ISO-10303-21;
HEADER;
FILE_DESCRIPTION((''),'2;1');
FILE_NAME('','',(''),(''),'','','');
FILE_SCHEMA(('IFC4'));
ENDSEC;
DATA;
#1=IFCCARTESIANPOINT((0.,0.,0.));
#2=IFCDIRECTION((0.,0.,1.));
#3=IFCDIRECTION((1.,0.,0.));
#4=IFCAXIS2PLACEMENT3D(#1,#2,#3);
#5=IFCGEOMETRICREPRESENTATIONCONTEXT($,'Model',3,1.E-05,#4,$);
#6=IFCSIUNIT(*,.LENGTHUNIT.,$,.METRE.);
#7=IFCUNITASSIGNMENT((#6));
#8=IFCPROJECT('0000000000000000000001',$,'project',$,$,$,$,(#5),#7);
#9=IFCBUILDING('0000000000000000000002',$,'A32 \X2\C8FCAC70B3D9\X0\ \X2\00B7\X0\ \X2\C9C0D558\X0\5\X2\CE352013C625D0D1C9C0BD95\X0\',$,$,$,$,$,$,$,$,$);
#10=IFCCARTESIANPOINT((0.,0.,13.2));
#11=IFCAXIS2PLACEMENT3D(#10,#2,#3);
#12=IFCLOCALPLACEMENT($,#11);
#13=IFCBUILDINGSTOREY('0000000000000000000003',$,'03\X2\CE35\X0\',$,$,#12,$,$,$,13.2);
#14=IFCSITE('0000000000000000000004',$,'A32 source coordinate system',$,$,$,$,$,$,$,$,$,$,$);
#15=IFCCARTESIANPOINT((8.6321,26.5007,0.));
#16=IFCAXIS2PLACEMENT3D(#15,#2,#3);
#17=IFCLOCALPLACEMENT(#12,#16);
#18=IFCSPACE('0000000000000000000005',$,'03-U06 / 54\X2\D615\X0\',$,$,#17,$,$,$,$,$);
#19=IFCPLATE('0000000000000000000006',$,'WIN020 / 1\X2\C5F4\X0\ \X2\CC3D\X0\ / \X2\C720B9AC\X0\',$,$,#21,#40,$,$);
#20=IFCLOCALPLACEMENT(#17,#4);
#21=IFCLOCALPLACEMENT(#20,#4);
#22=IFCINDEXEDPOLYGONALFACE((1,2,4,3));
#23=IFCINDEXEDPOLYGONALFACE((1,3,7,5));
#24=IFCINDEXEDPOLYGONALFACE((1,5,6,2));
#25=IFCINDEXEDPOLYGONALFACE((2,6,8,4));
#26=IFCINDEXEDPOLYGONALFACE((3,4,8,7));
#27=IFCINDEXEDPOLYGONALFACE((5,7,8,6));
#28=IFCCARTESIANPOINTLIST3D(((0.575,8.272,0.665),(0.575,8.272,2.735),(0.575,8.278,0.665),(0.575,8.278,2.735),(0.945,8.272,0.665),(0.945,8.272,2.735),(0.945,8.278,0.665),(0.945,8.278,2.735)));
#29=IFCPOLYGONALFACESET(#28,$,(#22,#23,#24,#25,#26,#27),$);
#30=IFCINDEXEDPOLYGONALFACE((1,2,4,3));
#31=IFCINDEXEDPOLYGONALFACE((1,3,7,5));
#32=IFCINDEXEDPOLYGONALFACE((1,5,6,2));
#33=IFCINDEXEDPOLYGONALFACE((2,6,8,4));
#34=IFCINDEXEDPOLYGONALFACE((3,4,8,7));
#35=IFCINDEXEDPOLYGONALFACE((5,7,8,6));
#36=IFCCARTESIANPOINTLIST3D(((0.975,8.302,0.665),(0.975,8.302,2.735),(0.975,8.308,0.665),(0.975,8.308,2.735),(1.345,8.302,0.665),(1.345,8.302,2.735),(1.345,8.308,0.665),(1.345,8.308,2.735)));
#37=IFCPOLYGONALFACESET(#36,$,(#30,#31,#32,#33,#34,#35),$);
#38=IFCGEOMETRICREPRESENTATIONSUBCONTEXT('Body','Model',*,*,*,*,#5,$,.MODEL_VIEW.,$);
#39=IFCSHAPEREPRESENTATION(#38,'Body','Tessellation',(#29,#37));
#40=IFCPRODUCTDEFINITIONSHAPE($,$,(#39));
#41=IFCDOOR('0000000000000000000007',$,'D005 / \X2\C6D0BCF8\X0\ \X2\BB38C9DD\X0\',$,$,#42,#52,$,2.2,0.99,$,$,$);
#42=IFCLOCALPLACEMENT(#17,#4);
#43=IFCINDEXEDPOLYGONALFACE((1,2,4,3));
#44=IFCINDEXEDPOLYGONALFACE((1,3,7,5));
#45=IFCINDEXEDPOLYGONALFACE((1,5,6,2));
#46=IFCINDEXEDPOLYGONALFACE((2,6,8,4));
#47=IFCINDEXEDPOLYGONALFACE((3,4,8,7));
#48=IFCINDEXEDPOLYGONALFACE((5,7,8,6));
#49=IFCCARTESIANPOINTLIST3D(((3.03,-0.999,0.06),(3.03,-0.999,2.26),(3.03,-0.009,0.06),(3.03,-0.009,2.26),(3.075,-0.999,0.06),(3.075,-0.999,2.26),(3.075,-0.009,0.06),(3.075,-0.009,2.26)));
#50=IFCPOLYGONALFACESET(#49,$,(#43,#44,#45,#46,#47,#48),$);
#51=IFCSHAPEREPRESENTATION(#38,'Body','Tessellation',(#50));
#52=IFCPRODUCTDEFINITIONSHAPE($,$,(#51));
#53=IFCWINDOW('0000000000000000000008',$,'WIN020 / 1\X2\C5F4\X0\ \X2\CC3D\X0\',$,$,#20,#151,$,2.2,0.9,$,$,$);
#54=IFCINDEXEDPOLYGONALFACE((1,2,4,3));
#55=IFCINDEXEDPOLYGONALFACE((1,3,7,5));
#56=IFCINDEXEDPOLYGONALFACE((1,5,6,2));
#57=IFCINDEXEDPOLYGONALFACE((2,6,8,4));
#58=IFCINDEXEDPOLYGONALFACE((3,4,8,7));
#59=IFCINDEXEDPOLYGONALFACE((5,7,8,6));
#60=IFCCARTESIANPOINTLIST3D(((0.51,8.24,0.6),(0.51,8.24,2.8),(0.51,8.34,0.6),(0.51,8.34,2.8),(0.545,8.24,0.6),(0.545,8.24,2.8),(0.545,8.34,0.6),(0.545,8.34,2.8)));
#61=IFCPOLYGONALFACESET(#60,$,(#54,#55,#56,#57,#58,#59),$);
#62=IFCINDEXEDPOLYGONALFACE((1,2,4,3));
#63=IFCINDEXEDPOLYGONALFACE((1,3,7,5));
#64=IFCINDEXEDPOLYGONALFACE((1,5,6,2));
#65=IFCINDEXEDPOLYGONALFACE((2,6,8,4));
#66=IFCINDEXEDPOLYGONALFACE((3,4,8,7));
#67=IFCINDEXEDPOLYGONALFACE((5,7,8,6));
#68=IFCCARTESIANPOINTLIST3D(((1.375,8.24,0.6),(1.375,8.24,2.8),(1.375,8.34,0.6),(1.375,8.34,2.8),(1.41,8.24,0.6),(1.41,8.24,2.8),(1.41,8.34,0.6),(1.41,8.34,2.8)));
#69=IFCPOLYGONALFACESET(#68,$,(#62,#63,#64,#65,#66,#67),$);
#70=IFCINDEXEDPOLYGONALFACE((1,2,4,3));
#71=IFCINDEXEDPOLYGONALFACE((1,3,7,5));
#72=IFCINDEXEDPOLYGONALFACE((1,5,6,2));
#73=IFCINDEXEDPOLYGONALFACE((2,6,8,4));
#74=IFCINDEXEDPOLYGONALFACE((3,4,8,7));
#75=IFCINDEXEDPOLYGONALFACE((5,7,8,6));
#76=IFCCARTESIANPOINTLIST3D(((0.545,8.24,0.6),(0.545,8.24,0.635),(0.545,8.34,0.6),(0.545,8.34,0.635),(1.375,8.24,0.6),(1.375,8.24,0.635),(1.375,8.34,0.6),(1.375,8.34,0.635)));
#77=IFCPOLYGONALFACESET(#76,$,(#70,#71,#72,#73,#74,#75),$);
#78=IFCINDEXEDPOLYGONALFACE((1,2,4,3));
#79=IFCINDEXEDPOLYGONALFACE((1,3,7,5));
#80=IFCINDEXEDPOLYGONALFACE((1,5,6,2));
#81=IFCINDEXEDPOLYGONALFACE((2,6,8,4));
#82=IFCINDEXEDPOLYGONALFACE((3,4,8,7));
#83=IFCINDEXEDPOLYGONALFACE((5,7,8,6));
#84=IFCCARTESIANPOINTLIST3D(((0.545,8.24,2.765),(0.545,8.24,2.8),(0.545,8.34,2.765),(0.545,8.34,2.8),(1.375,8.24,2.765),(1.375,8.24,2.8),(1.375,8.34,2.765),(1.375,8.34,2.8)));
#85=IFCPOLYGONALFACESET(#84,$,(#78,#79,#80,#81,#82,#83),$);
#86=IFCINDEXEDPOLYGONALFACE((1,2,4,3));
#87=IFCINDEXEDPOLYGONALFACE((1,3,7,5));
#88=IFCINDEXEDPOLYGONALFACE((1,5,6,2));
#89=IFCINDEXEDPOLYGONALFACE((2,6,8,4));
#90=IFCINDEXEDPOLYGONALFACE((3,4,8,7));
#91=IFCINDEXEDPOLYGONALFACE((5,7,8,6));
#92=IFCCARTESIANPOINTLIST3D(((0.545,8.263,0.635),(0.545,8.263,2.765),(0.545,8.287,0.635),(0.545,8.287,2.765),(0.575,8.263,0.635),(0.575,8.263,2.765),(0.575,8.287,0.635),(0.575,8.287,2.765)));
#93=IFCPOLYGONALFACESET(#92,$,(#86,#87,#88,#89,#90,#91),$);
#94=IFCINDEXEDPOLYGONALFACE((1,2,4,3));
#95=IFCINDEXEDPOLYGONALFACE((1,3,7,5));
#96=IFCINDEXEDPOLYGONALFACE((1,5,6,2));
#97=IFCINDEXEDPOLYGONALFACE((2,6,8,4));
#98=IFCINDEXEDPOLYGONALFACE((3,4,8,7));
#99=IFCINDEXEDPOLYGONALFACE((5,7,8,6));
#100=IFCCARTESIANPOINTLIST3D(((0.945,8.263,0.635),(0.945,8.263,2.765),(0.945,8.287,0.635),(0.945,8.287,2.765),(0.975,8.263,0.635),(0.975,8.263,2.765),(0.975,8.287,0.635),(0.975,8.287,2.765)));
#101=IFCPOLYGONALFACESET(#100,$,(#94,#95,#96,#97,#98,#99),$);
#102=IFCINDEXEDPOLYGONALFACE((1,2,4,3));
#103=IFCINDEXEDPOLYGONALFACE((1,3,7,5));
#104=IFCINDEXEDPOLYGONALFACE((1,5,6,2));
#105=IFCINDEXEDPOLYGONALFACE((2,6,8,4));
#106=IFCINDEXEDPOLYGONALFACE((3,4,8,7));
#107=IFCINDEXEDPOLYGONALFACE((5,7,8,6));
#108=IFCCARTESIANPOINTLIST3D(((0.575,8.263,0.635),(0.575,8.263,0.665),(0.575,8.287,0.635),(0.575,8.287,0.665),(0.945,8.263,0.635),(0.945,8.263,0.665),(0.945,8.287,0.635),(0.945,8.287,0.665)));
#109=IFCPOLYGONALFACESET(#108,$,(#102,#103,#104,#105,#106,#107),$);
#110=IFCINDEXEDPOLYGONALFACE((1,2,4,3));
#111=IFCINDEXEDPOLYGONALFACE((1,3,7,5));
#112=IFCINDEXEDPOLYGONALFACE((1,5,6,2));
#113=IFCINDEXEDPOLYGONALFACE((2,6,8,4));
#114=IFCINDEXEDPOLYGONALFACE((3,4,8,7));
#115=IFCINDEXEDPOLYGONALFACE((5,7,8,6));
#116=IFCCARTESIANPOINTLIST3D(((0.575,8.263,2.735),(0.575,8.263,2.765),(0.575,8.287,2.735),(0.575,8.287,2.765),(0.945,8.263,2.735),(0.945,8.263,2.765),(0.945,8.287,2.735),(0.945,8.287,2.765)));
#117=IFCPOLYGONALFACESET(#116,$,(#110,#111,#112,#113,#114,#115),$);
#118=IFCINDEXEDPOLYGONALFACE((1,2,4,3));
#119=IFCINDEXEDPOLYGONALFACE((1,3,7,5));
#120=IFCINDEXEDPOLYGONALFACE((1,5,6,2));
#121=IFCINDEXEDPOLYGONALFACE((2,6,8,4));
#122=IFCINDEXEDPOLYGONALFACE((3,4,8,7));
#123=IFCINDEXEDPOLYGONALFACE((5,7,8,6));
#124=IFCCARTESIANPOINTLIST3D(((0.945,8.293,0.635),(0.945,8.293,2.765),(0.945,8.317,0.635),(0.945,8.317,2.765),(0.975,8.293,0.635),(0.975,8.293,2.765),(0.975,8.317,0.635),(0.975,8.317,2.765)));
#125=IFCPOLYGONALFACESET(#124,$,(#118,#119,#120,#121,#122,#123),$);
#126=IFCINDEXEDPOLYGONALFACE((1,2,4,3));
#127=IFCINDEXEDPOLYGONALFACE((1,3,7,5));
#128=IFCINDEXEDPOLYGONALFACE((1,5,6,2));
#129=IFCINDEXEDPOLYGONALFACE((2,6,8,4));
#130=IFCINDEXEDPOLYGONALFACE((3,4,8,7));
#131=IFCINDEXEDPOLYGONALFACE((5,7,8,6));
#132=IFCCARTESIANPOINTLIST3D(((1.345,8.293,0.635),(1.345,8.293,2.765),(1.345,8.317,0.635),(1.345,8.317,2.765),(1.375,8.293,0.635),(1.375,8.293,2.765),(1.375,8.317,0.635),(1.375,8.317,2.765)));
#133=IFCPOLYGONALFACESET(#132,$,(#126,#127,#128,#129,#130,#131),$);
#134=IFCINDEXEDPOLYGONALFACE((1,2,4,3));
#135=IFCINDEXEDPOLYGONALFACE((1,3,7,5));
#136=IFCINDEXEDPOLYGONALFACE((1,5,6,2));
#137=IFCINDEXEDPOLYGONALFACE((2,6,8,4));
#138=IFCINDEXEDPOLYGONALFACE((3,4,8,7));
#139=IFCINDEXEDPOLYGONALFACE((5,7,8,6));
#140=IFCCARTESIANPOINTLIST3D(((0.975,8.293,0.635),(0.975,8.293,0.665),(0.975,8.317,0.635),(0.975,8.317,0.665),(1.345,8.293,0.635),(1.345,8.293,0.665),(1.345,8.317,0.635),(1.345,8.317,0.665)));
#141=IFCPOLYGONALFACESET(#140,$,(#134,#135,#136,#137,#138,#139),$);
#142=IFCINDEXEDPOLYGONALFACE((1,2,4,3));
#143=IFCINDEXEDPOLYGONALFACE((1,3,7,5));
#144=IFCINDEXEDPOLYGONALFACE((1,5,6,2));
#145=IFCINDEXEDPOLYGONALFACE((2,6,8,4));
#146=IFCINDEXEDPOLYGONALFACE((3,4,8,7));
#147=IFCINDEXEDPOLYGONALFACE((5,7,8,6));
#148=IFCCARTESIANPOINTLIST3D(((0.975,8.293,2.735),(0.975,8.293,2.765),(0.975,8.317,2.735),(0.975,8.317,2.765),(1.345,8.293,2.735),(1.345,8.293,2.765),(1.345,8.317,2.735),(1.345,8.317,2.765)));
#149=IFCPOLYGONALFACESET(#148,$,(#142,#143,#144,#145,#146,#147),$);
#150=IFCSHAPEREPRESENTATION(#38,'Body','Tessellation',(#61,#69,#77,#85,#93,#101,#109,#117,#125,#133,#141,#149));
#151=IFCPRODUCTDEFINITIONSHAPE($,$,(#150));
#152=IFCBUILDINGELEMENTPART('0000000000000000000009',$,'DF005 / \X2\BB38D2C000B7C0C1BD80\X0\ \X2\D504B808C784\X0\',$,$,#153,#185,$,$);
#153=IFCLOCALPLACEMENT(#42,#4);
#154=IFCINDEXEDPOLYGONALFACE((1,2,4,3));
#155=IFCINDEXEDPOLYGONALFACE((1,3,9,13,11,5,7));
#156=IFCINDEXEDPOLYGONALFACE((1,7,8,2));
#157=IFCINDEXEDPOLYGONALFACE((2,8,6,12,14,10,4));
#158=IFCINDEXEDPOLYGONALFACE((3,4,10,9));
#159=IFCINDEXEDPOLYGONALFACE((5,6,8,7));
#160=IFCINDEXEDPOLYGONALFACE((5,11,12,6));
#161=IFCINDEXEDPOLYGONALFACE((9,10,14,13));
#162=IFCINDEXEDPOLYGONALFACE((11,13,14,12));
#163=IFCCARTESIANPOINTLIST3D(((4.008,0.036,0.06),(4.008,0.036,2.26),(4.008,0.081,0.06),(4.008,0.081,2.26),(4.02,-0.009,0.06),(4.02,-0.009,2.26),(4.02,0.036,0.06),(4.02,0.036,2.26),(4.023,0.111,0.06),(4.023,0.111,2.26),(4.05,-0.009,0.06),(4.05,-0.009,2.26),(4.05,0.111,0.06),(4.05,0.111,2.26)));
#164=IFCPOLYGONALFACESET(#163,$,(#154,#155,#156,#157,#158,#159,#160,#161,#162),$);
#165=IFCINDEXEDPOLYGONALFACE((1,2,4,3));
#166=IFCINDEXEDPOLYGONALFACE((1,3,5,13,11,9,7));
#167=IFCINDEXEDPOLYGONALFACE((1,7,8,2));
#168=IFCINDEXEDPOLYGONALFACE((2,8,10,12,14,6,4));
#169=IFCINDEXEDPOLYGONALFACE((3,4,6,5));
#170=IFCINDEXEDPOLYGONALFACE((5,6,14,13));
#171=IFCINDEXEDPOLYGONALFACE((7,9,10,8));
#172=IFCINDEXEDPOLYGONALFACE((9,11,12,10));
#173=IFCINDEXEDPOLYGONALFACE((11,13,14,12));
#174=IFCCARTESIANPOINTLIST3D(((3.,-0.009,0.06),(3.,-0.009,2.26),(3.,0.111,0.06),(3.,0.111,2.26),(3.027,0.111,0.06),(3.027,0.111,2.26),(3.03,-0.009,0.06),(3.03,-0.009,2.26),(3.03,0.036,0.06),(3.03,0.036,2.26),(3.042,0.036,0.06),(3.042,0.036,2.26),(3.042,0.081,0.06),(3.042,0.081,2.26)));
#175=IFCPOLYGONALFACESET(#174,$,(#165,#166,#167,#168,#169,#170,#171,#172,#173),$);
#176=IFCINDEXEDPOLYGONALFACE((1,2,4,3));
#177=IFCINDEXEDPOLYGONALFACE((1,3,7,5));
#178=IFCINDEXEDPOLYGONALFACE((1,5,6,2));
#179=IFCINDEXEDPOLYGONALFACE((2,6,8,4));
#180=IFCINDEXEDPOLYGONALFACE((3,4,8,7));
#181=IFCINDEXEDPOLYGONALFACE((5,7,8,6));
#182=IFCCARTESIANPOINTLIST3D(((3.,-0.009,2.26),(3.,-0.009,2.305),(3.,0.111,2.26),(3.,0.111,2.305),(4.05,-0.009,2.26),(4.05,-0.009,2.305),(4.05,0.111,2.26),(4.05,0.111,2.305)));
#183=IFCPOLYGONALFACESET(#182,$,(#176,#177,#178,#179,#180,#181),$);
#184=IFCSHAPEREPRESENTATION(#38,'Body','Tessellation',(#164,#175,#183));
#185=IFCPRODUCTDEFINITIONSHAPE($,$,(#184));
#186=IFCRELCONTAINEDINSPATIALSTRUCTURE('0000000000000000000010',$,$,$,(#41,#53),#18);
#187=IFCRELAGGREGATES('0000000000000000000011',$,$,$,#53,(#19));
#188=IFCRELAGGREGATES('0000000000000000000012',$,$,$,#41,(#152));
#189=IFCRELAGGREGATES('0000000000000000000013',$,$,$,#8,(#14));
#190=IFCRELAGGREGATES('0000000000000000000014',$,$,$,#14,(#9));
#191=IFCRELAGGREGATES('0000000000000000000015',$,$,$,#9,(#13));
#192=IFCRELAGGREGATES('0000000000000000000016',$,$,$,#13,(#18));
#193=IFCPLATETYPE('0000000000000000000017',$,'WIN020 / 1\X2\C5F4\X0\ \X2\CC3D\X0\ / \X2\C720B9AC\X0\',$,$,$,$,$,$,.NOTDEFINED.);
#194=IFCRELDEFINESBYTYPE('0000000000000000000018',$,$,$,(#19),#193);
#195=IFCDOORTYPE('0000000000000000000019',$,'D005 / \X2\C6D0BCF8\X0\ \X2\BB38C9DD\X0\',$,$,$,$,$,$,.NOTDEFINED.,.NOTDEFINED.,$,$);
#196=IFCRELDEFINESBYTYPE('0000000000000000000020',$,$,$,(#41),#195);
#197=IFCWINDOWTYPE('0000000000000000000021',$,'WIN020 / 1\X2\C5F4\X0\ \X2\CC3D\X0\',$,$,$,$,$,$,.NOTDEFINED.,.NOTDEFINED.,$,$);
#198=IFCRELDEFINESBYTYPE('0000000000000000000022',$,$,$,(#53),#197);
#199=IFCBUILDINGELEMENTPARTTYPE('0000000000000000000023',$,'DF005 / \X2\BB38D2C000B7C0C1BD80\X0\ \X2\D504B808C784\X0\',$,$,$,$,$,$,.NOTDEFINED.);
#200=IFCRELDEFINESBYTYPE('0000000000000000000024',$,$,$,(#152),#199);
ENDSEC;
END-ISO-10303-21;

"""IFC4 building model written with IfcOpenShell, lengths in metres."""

from ifc_helpers import new_model, si_unit, frame, origin, origin_with_axes, place, context, subcontext, project, spatial, polyline, outline, extrude, source, transform, mapped, type_object, type_shapes, element, aggregate, save


model = new_model("IFC4")

# Units and contexts
model_context = context("Model", 3, precision=1e-05, world=origin_with_axes())
body_context = subcontext(model_context, "Body", "Model", "MODEL_VIEW")
ifc_project = project(units=[si_unit("LENGTHUNIT", "METRE")], contexts=[model_context])

# Plate
storey_placement = place(None, frame((0.0, 0.0, 13.2), z_axis=(0.0, 0.0, 1.0), x_axis=(1.0, 0.0, 0.0)))
space_1_placement = place(storey_placement, frame((8.6321, 26.5007, 0.0), z_axis=(0.0, 0.0, 1.0), x_axis=(1.0, 0.0, 0.0)))
plate_type_1 = type_object("IfcPlateType", Name="WIN020 / 1열 창 / 유리", PredefinedType="NOTDEFINED")
shared_shape_1 = source(origin(), body_context, "Body", "SweptSolid", [
    extrude(outline(polyline([(0.575, 8.272), (0.575, 8.278), (0.945, 8.278), (0.945, 8.272), (0.575, 8.272)])), frame((0.0, 0.0, 0.665)), (0.0, 0.0, 1.0), 2.07),
    extrude(outline(polyline([(0.975, 8.302), (0.975, 8.308), (1.345, 8.308), (1.345, 8.302), (0.975, 8.302)])), frame((0.0, 0.0, 0.665)), (0.0, 0.0, 1.0), 2.07),
])
type_shapes(plate_type_1, [shared_shape_1])
window_1_placement = place(space_1_placement, origin_with_axes())
plate_1_placement = place(window_1_placement, origin_with_axes())
plate_1 = element("IfcPlate", 1, at=plate_1_placement, type_object=plate_type_1, Name="WIN020 / 1열 창 / 유리", context=body_context, shape_type="MappedRepresentation", body=[
    mapped(shared_shape_1, transform((0.0, 0.0, 0.0), scale=1.0)),
])

# Site, building, storey, space
site = spatial("IfcSite", under=ifc_project, Name="A32 source coordinate system")
building = spatial("IfcBuilding", under=site, Name="A32 주거동 · 지하5층–옥탑지붕")
storey = spatial("IfcBuildingStorey", under=building, at=storey_placement, Name="03층", Elevation=13.2)
space_1 = spatial("IfcSpace", under=storey, at=space_1_placement, Name="03-U06 / 54형")

# Door
door_type_1 = type_object("IfcDoorType", Name="D005 / 원본 문짝", OperationType="NOTDEFINED", PredefinedType="NOTDEFINED")
shared_shape_2 = source(origin(), body_context, "Body", "SweptSolid", [
    extrude(outline(polyline([(3.075, -0.999), (3.03, -0.999), (3.03, -0.009), (3.075, -0.009), (3.075, -0.999)])), frame((0.0, 0.0, 0.06)), (0.0, 0.0, 1.0), 2.2),
])
type_shapes(door_type_1, [shared_shape_2])
door_1_placement = place(space_1_placement, origin_with_axes())
door_1 = element("IfcDoor", 2, at=door_1_placement, inside=space_1, type_object=door_type_1, Name="D005 / 원본 문짝", OverallHeight=2.2, OverallWidth=0.99, context=body_context, shape_type="MappedRepresentation", body=[
    mapped(shared_shape_2, transform((0.0, 0.0, 0.0), scale=1.0)),
])

# Window
window_type_1 = type_object("IfcWindowType", Name="WIN020 / 1열 창", PartitioningType="NOTDEFINED", PredefinedType="NOTDEFINED")
shared_shape_3 = source(origin(), body_context, "Body", "SweptSolid", [
    extrude(outline(polyline([(0.51, 8.24), (0.51, 8.34), (0.545, 8.34), (0.545, 8.24), (0.51, 8.24)])), frame((0.0, 0.0, 0.6)), (0.0, 0.0, 1.0), 2.2),
    extrude(outline(polyline([(1.375, 8.24), (1.375, 8.34), (1.41, 8.34), (1.41, 8.24), (1.375, 8.24)])), frame((0.0, 0.0, 0.6)), (0.0, 0.0, 1.0), 2.2),
    extrude(outline(polyline([(0.545, 8.24), (0.545, 8.34), (1.375, 8.34), (1.375, 8.24), (0.545, 8.24)])), frame((0.0, 0.0, 0.6)), (0.0, 0.0, 1.0), 0.035),
    extrude(outline(polyline([(0.545, 8.24), (0.545, 8.34), (1.375, 8.34), (1.375, 8.24), (0.545, 8.24)])), frame((0.0, 0.0, 2.765)), (0.0, 0.0, 1.0), 0.035),
    extrude(outline(polyline([(0.545, 8.263), (0.545, 8.287), (0.575, 8.287), (0.575, 8.263), (0.545, 8.263)])), frame((0.0, 0.0, 0.635)), (0.0, 0.0, 1.0), 2.13),
    extrude(outline(polyline([(0.945, 8.263), (0.945, 8.287), (0.975, 8.287), (0.975, 8.263), (0.945, 8.263)])), frame((0.0, 0.0, 0.635)), (0.0, 0.0, 1.0), 2.13),
    extrude(outline(polyline([(0.575, 8.263), (0.575, 8.287), (0.945, 8.287), (0.945, 8.263), (0.575, 8.263)])), frame((0.0, 0.0, 0.635)), (0.0, 0.0, 1.0), 0.03),
    extrude(outline(polyline([(0.575, 8.263), (0.575, 8.287), (0.945, 8.287), (0.945, 8.263), (0.575, 8.263)])), frame((0.0, 0.0, 2.735)), (0.0, 0.0, 1.0), 0.03),
    extrude(outline(polyline([(0.945, 8.293), (0.945, 8.317), (0.975, 8.317), (0.975, 8.293), (0.945, 8.293)])), frame((0.0, 0.0, 0.635)), (0.0, 0.0, 1.0), 2.13),
    extrude(outline(polyline([(1.345, 8.293), (1.345, 8.317), (1.375, 8.317), (1.375, 8.293), (1.345, 8.293)])), frame((0.0, 0.0, 0.635)), (0.0, 0.0, 1.0), 2.13),
    extrude(outline(polyline([(0.975, 8.293), (0.975, 8.317), (1.345, 8.317), (1.345, 8.293), (0.975, 8.293)])), frame((0.0, 0.0, 0.635)), (0.0, 0.0, 1.0), 0.03),
    extrude(outline(polyline([(0.975, 8.293), (0.975, 8.317), (1.345, 8.317), (1.345, 8.293), (0.975, 8.293)])), frame((0.0, 0.0, 2.735)), (0.0, 0.0, 1.0), 0.03),
])
type_shapes(window_type_1, [shared_shape_3])
window_1 = element("IfcWindow", 3, at=window_1_placement, inside=space_1, type_object=window_type_1, Name="WIN020 / 1열 창", OverallHeight=2.2, OverallWidth=0.9, context=body_context, shape_type="MappedRepresentation", body=[
    mapped(shared_shape_3, transform((0.0, 0.0, 0.0), scale=1.0)),
])
aggregate(window_1, [plate_1])

# Building element part
building_element_part_type_1 = type_object("IfcBuildingElementPartType", Name="DF005 / 문틀·상부 프레임", PredefinedType="NOTDEFINED")
shared_shape_4 = source(origin(), body_context, "Body", "SweptSolid", [
    extrude(outline(polyline([(4.02, -0.009), (4.02, 0.036), (4.008, 0.036), (4.008, 0.081), (4.023, 0.111), (4.05, 0.111), (4.05, -0.009), (4.02, -0.009)])), frame((0.0, 0.0, 0.06)), (0.0, 0.0, 1.0), 2.2),
    extrude(outline(polyline([(3.0, 0.111), (3.027, 0.111), (3.042, 0.081), (3.042, 0.036), (3.03, 0.036), (3.03, -0.009), (3.0, -0.009), (3.0, 0.111)])), frame((0.0, 0.0, 0.06)), (0.0, 0.0, 1.0), 2.2),
    extrude(outline(polyline([(3.0, -0.009), (3.0, 0.111), (4.05, 0.111), (4.05, -0.009), (3.0, -0.009)])), frame((0.0, 0.0, 2.26)), (0.0, 0.0, 1.0), 0.045),
])
type_shapes(building_element_part_type_1, [shared_shape_4])
building_element_part_1_placement = place(door_1_placement, origin_with_axes())
building_element_part_1 = element("IfcBuildingElementPart", 4, at=building_element_part_1_placement, type_object=building_element_part_type_1, Name="DF005 / 문틀·상부 프레임", context=body_context, shape_type="MappedRepresentation", body=[
    mapped(shared_shape_4, transform((0.0, 0.0, 0.0), scale=1.0)),
])
aggregate(door_1, [building_element_part_1])

save(model, "model.ifc")
